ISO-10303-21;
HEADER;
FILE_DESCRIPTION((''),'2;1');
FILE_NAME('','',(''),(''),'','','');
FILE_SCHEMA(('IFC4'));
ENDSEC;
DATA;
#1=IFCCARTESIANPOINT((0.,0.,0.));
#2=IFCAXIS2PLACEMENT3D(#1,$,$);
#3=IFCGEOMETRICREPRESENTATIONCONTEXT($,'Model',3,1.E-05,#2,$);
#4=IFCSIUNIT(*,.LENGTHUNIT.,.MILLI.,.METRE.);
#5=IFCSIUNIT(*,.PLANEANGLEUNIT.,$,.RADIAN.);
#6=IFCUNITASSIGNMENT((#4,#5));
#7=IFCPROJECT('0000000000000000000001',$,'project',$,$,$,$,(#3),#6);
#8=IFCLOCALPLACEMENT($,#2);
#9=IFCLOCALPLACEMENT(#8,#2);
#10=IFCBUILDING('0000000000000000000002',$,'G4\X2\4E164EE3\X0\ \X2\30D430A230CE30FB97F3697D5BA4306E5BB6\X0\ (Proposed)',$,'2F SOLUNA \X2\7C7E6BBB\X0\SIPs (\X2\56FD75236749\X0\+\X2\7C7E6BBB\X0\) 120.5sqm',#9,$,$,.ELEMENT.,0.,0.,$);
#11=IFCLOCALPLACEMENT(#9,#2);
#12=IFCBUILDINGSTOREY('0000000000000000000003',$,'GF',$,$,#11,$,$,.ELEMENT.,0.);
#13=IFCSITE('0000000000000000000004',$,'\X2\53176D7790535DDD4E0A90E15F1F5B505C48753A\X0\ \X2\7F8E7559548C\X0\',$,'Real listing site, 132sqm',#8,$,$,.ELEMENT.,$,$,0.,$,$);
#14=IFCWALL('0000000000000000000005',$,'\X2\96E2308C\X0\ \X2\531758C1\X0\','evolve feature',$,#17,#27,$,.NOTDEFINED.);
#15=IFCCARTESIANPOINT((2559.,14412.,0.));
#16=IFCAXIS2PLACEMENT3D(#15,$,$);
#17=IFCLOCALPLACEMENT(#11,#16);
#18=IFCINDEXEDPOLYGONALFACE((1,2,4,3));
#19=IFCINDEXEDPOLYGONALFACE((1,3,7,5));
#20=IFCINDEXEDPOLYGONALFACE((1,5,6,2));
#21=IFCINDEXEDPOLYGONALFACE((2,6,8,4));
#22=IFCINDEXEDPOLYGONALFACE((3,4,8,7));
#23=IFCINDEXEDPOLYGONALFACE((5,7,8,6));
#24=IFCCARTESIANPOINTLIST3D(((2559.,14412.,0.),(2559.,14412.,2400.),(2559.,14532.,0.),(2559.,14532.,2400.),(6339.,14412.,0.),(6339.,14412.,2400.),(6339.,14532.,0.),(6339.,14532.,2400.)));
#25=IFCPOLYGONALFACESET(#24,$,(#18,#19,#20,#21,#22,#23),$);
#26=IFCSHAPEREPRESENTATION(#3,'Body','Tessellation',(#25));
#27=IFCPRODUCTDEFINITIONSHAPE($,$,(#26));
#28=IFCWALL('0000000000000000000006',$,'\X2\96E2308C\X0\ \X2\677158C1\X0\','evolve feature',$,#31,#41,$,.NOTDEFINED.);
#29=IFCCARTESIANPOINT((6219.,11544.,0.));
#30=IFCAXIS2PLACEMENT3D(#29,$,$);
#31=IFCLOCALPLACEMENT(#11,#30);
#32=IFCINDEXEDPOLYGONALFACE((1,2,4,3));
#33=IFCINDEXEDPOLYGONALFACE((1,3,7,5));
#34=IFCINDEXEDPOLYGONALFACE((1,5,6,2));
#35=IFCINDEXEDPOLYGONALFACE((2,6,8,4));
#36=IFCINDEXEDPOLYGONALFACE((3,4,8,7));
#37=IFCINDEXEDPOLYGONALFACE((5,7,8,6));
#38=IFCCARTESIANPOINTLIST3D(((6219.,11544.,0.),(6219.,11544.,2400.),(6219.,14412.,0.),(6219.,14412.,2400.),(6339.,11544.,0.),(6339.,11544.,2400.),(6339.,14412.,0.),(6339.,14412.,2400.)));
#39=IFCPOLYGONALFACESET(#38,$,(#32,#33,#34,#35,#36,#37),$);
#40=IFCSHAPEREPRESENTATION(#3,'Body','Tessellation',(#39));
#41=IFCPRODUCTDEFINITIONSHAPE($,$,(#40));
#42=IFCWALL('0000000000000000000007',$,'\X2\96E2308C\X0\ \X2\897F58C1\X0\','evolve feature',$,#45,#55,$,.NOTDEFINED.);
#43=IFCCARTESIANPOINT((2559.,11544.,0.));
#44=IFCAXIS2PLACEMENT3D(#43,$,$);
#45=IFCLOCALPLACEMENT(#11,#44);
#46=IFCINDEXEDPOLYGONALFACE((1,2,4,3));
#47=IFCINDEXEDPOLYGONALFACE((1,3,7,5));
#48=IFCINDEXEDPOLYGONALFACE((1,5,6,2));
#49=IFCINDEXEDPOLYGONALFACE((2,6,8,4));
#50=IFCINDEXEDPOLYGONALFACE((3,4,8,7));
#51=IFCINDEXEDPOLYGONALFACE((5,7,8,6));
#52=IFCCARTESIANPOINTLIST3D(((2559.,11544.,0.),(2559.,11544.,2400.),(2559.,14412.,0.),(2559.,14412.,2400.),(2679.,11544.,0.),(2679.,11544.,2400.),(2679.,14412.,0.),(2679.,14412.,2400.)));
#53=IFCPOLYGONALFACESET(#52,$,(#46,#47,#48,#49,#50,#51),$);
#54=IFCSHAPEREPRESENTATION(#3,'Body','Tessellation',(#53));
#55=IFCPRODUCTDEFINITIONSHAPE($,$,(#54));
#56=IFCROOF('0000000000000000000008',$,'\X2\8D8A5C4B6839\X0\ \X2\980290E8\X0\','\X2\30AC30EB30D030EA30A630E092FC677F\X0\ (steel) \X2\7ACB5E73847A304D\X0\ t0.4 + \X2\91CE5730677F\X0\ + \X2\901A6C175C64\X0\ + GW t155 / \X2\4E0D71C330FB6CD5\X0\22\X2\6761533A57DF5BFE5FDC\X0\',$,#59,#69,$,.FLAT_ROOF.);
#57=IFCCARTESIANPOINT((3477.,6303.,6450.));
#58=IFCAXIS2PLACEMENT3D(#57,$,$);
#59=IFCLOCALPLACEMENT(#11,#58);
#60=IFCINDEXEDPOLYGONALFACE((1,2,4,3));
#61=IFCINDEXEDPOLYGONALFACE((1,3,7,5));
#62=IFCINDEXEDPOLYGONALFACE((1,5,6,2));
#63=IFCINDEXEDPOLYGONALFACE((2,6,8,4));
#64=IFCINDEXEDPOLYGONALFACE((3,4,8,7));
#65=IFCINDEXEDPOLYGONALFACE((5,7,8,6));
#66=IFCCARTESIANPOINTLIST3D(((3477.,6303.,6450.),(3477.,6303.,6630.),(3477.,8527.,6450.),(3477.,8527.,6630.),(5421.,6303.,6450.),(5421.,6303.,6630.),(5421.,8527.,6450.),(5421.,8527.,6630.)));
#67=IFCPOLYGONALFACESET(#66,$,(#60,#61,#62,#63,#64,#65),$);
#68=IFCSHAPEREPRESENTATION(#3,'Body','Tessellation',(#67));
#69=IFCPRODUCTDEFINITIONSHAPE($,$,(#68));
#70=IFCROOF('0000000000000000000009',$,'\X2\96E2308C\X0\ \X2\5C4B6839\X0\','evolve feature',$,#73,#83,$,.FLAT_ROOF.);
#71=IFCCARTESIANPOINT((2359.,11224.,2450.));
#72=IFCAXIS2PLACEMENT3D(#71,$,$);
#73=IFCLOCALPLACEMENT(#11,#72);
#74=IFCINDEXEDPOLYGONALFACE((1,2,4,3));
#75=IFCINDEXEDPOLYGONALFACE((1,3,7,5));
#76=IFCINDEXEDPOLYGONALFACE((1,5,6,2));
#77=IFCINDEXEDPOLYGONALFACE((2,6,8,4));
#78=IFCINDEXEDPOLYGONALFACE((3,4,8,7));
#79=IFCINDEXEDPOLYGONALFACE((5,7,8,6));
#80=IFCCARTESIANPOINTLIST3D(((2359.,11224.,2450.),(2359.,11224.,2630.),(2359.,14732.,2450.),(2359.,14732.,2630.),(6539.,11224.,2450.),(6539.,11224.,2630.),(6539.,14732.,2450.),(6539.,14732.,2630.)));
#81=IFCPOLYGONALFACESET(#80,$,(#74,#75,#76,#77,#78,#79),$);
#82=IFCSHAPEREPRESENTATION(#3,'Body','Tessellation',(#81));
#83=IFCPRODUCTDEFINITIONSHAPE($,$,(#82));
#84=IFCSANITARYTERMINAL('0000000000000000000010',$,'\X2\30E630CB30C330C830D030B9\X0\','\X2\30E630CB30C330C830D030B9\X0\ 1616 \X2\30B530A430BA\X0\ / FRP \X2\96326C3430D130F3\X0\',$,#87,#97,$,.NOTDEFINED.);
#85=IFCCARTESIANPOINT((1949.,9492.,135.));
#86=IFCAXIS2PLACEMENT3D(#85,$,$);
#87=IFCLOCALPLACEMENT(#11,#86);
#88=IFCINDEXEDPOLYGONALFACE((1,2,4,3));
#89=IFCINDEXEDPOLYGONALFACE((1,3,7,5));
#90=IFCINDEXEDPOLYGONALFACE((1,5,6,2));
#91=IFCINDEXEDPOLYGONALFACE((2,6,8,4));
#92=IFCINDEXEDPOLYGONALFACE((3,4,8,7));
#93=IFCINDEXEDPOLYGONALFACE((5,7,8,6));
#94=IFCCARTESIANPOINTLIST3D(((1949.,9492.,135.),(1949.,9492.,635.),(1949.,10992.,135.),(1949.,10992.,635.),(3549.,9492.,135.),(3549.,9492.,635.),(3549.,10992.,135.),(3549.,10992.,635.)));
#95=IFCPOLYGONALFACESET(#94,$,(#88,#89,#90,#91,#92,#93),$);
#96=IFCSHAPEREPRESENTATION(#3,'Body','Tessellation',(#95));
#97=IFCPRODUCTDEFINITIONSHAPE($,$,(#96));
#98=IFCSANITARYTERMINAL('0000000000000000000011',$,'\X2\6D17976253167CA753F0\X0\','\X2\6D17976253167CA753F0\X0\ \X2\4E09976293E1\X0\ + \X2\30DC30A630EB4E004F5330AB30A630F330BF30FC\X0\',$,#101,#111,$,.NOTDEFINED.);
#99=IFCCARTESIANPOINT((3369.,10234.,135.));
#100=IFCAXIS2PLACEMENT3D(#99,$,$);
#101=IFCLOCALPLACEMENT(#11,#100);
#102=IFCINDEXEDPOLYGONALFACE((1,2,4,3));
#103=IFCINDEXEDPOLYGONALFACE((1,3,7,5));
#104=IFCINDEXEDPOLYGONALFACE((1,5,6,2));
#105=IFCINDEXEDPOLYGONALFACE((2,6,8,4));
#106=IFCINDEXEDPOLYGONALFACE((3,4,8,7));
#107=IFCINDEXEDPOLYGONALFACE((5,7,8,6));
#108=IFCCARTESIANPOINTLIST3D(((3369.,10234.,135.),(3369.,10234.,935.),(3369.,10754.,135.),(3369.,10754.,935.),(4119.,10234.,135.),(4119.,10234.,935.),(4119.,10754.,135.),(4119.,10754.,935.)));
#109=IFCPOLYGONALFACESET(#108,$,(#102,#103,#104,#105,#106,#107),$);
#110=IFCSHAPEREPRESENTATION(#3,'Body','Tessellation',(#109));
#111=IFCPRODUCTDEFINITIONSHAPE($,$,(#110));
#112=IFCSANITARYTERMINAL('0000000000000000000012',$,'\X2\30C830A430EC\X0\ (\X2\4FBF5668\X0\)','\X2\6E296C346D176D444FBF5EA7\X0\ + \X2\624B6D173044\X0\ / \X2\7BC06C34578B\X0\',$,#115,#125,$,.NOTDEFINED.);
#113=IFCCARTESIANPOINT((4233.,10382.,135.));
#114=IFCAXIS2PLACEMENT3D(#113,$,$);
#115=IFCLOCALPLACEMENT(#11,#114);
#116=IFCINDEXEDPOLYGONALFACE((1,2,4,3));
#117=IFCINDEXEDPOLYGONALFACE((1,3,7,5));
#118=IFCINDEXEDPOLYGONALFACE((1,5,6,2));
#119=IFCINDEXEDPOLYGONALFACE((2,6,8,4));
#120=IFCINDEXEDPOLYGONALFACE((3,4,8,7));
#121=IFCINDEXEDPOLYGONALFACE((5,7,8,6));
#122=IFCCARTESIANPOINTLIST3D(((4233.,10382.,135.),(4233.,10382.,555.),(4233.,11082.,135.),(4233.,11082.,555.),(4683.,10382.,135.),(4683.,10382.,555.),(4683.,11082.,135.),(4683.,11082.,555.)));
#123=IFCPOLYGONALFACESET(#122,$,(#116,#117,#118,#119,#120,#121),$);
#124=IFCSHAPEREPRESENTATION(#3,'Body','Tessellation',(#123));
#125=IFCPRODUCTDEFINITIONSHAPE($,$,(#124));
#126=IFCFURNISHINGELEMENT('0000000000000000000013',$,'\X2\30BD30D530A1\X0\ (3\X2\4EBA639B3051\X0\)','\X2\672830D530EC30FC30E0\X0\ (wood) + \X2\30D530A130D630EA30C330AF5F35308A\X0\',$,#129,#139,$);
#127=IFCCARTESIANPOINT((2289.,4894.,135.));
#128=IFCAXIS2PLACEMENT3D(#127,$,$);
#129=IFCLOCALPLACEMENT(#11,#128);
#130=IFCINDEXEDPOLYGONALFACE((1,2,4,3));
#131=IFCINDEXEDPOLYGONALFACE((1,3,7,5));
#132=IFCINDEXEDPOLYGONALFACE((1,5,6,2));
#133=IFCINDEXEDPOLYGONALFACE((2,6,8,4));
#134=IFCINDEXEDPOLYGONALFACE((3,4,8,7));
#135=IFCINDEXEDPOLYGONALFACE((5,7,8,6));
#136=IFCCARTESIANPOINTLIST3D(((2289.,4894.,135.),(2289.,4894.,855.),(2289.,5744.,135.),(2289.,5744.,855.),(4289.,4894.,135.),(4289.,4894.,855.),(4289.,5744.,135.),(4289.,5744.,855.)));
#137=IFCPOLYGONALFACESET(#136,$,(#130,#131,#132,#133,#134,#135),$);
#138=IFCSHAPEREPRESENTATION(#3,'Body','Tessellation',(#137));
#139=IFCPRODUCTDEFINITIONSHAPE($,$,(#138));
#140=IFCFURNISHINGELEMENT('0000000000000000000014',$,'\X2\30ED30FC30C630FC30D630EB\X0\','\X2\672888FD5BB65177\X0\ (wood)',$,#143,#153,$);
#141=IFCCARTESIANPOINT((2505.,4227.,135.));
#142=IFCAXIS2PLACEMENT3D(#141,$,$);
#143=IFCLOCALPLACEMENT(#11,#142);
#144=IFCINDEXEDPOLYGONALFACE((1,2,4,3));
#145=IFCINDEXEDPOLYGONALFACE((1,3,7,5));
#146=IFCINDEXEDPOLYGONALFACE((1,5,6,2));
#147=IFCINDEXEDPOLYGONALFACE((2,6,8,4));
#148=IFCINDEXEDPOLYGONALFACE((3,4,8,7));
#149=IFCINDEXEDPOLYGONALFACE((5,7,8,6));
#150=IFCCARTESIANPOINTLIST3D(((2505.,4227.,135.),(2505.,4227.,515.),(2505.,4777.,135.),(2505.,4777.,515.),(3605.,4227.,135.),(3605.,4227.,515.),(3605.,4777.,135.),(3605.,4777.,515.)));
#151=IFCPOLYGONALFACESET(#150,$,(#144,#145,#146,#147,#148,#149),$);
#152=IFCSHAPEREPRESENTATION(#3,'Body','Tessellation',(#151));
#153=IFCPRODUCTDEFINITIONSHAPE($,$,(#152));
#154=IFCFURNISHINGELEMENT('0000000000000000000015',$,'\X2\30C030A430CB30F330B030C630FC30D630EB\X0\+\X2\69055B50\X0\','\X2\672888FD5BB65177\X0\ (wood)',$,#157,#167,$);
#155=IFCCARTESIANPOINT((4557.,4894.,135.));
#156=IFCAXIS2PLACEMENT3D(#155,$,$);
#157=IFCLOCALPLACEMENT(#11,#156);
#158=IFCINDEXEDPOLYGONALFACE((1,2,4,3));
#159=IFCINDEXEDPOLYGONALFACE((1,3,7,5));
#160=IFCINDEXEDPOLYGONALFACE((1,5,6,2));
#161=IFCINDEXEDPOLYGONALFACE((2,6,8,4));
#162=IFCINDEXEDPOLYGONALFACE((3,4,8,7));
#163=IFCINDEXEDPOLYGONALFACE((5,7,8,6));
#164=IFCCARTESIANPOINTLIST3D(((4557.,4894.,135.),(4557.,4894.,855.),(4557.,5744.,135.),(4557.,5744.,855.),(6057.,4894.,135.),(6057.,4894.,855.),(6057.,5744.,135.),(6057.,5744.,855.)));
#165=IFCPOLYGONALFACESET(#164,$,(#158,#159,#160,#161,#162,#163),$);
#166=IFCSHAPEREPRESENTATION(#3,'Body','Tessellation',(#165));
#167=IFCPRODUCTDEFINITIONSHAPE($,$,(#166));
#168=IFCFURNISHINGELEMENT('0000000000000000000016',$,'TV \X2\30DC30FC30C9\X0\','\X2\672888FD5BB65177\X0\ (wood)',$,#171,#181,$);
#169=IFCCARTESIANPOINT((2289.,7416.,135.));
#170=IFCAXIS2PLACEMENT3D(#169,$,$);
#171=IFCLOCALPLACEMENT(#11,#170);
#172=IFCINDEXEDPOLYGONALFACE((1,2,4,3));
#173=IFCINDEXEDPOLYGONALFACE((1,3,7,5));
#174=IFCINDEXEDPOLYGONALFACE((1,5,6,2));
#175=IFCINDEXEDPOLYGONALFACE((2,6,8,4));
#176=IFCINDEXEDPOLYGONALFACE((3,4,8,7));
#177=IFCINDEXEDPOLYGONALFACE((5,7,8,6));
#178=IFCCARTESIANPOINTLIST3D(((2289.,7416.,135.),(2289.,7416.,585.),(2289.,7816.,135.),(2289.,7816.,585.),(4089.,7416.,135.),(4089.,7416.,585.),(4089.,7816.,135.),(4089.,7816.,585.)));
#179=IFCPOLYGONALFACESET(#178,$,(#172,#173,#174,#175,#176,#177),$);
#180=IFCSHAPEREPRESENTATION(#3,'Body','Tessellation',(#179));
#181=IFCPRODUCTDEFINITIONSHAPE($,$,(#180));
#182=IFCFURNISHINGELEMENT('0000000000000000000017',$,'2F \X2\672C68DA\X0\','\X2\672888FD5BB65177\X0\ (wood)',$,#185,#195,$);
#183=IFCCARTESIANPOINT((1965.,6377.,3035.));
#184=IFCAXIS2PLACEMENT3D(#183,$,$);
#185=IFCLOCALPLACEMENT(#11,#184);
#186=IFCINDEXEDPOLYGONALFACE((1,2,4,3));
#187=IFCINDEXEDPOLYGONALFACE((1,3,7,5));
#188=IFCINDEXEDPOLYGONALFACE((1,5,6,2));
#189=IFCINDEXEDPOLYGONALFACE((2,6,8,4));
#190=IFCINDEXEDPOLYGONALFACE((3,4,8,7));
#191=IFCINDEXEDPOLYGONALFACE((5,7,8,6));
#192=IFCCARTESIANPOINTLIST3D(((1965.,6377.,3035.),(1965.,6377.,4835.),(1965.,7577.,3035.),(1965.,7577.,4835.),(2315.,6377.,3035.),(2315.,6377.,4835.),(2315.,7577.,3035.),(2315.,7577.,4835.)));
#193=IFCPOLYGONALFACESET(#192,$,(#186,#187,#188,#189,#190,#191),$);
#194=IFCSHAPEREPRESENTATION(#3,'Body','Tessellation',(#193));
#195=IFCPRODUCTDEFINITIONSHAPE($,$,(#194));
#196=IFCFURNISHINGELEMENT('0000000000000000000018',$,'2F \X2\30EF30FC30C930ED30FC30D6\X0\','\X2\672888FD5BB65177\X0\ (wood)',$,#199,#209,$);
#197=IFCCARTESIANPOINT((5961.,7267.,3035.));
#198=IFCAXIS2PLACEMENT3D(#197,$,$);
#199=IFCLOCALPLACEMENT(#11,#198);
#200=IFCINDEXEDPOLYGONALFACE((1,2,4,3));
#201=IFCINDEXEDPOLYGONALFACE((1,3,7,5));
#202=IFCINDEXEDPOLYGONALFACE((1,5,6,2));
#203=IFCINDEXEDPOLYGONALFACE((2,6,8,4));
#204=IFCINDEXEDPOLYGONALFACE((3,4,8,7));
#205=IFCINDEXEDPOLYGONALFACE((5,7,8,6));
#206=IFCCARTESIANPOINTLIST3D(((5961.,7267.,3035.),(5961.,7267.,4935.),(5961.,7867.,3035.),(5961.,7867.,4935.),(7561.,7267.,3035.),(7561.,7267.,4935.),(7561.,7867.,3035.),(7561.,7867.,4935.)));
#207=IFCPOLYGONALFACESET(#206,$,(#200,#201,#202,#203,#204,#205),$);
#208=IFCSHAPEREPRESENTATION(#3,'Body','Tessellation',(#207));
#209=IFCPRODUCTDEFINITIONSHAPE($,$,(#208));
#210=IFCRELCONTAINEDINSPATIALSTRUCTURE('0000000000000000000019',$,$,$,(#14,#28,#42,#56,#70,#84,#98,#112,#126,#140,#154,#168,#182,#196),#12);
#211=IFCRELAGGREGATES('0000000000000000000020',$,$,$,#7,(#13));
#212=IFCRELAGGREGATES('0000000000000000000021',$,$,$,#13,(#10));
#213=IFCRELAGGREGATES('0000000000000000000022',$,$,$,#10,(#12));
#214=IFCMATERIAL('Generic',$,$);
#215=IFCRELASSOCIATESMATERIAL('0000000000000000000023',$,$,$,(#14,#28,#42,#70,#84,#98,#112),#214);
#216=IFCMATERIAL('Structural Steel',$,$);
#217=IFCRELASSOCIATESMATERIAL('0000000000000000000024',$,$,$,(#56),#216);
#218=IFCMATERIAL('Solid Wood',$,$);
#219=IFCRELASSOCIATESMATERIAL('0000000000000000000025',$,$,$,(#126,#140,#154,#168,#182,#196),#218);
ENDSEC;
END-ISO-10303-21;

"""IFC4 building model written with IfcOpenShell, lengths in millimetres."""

from ifc_helpers import new_model, si_unit, frame, frame_2d, origin, place, context, project, spatial, rectangle, extrude, material, element, save


model = new_model("IFC4")

# Units and contexts
model_context = context("Model", 3, precision=1e-05, world=origin())
ifc_project = project(units=[si_unit("LENGTHUNIT", "METRE", prefix="MILLI"), si_unit("PLANEANGLEUNIT", "RADIAN")], contexts=[model_context])

# Site, building, storey
site_placement = place(None, origin())
site = spatial("IfcSite", under=ifc_project, at=site_placement, Name="北海道川上郡弟子屈町 美留和", ObjectType="Real listing site, 132sqm", CompositionType="ELEMENT", RefElevation=0.0)
building_placement = place(site_placement, origin())
building = spatial("IfcBuilding", under=site, at=building_placement, Name="G4世代 ピアノ・音楽室の家 (Proposed)", ObjectType="2F SOLUNA 籾殻SIPs (国産杉+籾殻) 120.5sqm", CompositionType="ELEMENT", ElevationOfRefHeight=0.0, ElevationOfTerrain=0.0)
storey_placement = place(building_placement, origin())
storey = spatial("IfcBuildingStorey", under=building, at=storey_placement, Name="GF", CompositionType="ELEMENT", Elevation=0.0)

# Shared definitions
ifc_material_1 = material(Name="Generic")

# Shared definitions
ifc_material_2 = material(Name="Solid Wood")

# Walls
wall_1_placement = place(storey_placement, frame((2559.0, 14412.0, 0.0)))
element("IfcWall", 1, at=wall_1_placement, inside=storey, material=ifc_material_1, Name="離れ 北壁", Description="evolve feature", PredefinedType="NOTDEFINED", context=model_context, shape_type="SweptSolid", body=[
    extrude(rectangle(XDim=3780.0, YDim=120.0, at=frame_2d((1890.0, 60.0))), frame((2559.0, 14412.0, 0.0)), (0.0, 0.0, 1.0), 2400.0),
])
wall_2_placement = place(storey_placement, frame((6219.0, 11544.0, 0.0)))
element("IfcWall", 2, at=wall_2_placement, inside=storey, material=ifc_material_1, Name="離れ 東壁", Description="evolve feature", PredefinedType="NOTDEFINED", context=model_context, shape_type="SweptSolid", body=[
    extrude(rectangle(XDim=120.0, YDim=2868.0, at=frame_2d((60.0, 1434.0))), frame((6219.0, 11544.0, 0.0)), (0.0, 0.0, 1.0), 2400.0),
])
wall_3_placement = place(storey_placement, frame((2559.0, 11544.0, 0.0)))
element("IfcWall", 3, at=wall_3_placement, inside=storey, material=ifc_material_1, Name="離れ 西壁", Description="evolve feature", PredefinedType="NOTDEFINED", context=model_context, shape_type="SweptSolid", body=[
    extrude(rectangle(XDim=120.0, YDim=2868.0, at=frame_2d((60.0, 1434.0))), frame((2559.0, 11544.0, 0.0)), (0.0, 0.0, 1.0), 2400.0),
])

# Roofs
ifc_material_3 = material(Name="Structural Steel")
roof_1_placement = place(storey_placement, frame((3477.0, 6303.0, 6450.0)))
element("IfcRoof", 4, at=roof_1_placement, inside=storey, material=ifc_material_3, Name="越屋根 頂部", Description="ガルバリウム鋼板 (steel) 立平葺き t0.4 + 野地板 + 通気層 + GW t155 / 不燃・法22条区域対応", PredefinedType="FLAT_ROOF", context=model_context, shape_type="SweptSolid", body=[
    extrude(rectangle(XDim=1944.0, YDim=2224.0, at=frame_2d((972.0, 1112.0))), frame((3477.0, 6303.0, 6450.0)), (0.0, 0.0, 1.0), 180.0),
])
roof_2_placement = place(storey_placement, frame((2359.0, 11224.0, 2450.0)))
element("IfcRoof", 5, at=roof_2_placement, inside=storey, material=ifc_material_1, Name="離れ 屋根", Description="evolve feature", PredefinedType="FLAT_ROOF", context=model_context, shape_type="SweptSolid", body=[
    extrude(rectangle(XDim=4180.0, YDim=3508.0, at=frame_2d((2090.0, 1754.0))), frame((2359.0, 11224.0, 2450.0)), (0.0, 0.0, 1.0), 180.0),
])

# Sanitary terminals
sanitary_terminal_1_placement = place(storey_placement, frame((1949.0, 9492.0, 135.0)))
element("IfcSanitaryTerminal", 6, at=sanitary_terminal_1_placement, inside=storey, material=ifc_material_1, Name="ユニットバス", Description="ユニットバス 1616 サイズ / FRP 防水パン", PredefinedType="NOTDEFINED", context=model_context, shape_type="SweptSolid", body=[
    extrude(rectangle(XDim=1600.0, YDim=1500.0, at=frame_2d((800.0, 750.0))), frame((1949.0, 9492.0, 135.0)), (0.0, 0.0, 1.0), 500.0),
])
sanitary_terminal_2_placement = place(storey_placement, frame((3369.0, 10234.0, 135.0)))
element("IfcSanitaryTerminal", 7, at=sanitary_terminal_2_placement, inside=storey, material=ifc_material_1, Name="洗面化粧台", Description="洗面化粧台 三面鏡 + ボウル一体カウンター", PredefinedType="NOTDEFINED", context=model_context, shape_type="SweptSolid", body=[
    extrude(rectangle(XDim=750.0, YDim=520.0, at=frame_2d((375.0, 260.0))), frame((3369.0, 10234.0, 135.0)), (0.0, 0.0, 1.0), 800.0),
])
sanitary_terminal_3_placement = place(storey_placement, frame((4233.0, 10382.0, 135.0)))
element("IfcSanitaryTerminal", 8, at=sanitary_terminal_3_placement, inside=storey, material=ifc_material_1, Name="トイレ (便器)", Description="温水洗浄便座 + 手洗い / 節水型", PredefinedType="NOTDEFINED", context=model_context, shape_type="SweptSolid", body=[
    extrude(rectangle(XDim=450.0, YDim=700.0, at=frame_2d((225.0, 350.0))), frame((4233.0, 10382.0, 135.0)), (0.0, 0.0, 1.0), 420.0),
])

# Furnishing elements
furnishing_1_placement = place(storey_placement, frame((2289.0, 4894.0, 135.0)))
element("IfcFurnishingElement", 9, at=furnishing_1_placement, inside=storey, material=ifc_material_2, Name="ソファ (3人掛け)", Description="木フレーム (wood) + ファブリック張り", context=model_context, shape_type="SweptSolid", body=[
    extrude(rectangle(XDim=2000.0, YDim=850.0, at=frame_2d((1000.0, 425.0))), frame((2289.0, 4894.0, 135.0)), (0.0, 0.0, 1.0), 720.0),
])
furnishing_2_placement = place(storey_placement, frame((2505.0, 4227.0, 135.0)))
element("IfcFurnishingElement", 10, at=furnishing_2_placement, inside=storey, material=ifc_material_2, Name="ローテーブル", Description="木製家具 (wood)", context=model_context, shape_type="SweptSolid", body=[
    extrude(rectangle(XDim=1100.0, YDim=550.0, at=frame_2d((550.0, 275.0))), frame((2505.0, 4227.0, 135.0)), (0.0, 0.0, 1.0), 380.0),
])
furnishing_3_placement = place(storey_placement, frame((4557.0, 4894.0, 135.0)))
element("IfcFurnishingElement", 11, at=furnishing_3_placement, inside=storey, material=ifc_material_2, Name="ダイニングテーブル+椅子", Description="木製家具 (wood)", context=model_context, shape_type="SweptSolid", body=[
    extrude(rectangle(XDim=1500.0, YDim=850.0, at=frame_2d((750.0, 425.0))), frame((4557.0, 4894.0, 135.0)), (0.0, 0.0, 1.0), 720.0),
])
furnishing_4_placement = place(storey_placement, frame((2289.0, 7416.0, 135.0)))
element("IfcFurnishingElement", 12, at=furnishing_4_placement, inside=storey, material=ifc_material_2, Name="TV ボード", Description="木製家具 (wood)", context=model_context, shape_type="SweptSolid", body=[
    extrude(rectangle(XDim=1800.0, YDim=400.0, at=frame_2d((900.0, 200.0))), frame((2289.0, 7416.0, 135.0)), (0.0, 0.0, 1.0), 450.0),
])
furnishing_5_placement = place(storey_placement, frame((1965.0, 6377.0, 3035.0)))
element("IfcFurnishingElement", 13, at=furnishing_5_placement, inside=storey, material=ifc_material_2, Name="2F 本棚", Description="木製家具 (wood)", context=model_context, shape_type="SweptSolid", body=[
    extrude(rectangle(XDim=350.0, YDim=1200.0, at=frame_2d((175.0, 600.0))), frame((1965.0, 6377.0, 3035.0)), (0.0, 0.0, 1.0), 1800.0),
])
furnishing_6_placement = place(storey_placement, frame((5961.0, 7267.0, 3035.0)))
element("IfcFurnishingElement", 14, at=furnishing_6_placement, inside=storey, material=ifc_material_2, Name="2F ワードローブ", Description="木製家具 (wood)", context=model_context, shape_type="SweptSolid", body=[
    extrude(rectangle(XDim=1600.0, YDim=600.0, at=frame_2d((800.0, 300.0))), frame((5961.0, 7267.0, 3035.0)), (0.0, 0.0, 1.0), 1900.0),
])

save(model, "model.ifc")
